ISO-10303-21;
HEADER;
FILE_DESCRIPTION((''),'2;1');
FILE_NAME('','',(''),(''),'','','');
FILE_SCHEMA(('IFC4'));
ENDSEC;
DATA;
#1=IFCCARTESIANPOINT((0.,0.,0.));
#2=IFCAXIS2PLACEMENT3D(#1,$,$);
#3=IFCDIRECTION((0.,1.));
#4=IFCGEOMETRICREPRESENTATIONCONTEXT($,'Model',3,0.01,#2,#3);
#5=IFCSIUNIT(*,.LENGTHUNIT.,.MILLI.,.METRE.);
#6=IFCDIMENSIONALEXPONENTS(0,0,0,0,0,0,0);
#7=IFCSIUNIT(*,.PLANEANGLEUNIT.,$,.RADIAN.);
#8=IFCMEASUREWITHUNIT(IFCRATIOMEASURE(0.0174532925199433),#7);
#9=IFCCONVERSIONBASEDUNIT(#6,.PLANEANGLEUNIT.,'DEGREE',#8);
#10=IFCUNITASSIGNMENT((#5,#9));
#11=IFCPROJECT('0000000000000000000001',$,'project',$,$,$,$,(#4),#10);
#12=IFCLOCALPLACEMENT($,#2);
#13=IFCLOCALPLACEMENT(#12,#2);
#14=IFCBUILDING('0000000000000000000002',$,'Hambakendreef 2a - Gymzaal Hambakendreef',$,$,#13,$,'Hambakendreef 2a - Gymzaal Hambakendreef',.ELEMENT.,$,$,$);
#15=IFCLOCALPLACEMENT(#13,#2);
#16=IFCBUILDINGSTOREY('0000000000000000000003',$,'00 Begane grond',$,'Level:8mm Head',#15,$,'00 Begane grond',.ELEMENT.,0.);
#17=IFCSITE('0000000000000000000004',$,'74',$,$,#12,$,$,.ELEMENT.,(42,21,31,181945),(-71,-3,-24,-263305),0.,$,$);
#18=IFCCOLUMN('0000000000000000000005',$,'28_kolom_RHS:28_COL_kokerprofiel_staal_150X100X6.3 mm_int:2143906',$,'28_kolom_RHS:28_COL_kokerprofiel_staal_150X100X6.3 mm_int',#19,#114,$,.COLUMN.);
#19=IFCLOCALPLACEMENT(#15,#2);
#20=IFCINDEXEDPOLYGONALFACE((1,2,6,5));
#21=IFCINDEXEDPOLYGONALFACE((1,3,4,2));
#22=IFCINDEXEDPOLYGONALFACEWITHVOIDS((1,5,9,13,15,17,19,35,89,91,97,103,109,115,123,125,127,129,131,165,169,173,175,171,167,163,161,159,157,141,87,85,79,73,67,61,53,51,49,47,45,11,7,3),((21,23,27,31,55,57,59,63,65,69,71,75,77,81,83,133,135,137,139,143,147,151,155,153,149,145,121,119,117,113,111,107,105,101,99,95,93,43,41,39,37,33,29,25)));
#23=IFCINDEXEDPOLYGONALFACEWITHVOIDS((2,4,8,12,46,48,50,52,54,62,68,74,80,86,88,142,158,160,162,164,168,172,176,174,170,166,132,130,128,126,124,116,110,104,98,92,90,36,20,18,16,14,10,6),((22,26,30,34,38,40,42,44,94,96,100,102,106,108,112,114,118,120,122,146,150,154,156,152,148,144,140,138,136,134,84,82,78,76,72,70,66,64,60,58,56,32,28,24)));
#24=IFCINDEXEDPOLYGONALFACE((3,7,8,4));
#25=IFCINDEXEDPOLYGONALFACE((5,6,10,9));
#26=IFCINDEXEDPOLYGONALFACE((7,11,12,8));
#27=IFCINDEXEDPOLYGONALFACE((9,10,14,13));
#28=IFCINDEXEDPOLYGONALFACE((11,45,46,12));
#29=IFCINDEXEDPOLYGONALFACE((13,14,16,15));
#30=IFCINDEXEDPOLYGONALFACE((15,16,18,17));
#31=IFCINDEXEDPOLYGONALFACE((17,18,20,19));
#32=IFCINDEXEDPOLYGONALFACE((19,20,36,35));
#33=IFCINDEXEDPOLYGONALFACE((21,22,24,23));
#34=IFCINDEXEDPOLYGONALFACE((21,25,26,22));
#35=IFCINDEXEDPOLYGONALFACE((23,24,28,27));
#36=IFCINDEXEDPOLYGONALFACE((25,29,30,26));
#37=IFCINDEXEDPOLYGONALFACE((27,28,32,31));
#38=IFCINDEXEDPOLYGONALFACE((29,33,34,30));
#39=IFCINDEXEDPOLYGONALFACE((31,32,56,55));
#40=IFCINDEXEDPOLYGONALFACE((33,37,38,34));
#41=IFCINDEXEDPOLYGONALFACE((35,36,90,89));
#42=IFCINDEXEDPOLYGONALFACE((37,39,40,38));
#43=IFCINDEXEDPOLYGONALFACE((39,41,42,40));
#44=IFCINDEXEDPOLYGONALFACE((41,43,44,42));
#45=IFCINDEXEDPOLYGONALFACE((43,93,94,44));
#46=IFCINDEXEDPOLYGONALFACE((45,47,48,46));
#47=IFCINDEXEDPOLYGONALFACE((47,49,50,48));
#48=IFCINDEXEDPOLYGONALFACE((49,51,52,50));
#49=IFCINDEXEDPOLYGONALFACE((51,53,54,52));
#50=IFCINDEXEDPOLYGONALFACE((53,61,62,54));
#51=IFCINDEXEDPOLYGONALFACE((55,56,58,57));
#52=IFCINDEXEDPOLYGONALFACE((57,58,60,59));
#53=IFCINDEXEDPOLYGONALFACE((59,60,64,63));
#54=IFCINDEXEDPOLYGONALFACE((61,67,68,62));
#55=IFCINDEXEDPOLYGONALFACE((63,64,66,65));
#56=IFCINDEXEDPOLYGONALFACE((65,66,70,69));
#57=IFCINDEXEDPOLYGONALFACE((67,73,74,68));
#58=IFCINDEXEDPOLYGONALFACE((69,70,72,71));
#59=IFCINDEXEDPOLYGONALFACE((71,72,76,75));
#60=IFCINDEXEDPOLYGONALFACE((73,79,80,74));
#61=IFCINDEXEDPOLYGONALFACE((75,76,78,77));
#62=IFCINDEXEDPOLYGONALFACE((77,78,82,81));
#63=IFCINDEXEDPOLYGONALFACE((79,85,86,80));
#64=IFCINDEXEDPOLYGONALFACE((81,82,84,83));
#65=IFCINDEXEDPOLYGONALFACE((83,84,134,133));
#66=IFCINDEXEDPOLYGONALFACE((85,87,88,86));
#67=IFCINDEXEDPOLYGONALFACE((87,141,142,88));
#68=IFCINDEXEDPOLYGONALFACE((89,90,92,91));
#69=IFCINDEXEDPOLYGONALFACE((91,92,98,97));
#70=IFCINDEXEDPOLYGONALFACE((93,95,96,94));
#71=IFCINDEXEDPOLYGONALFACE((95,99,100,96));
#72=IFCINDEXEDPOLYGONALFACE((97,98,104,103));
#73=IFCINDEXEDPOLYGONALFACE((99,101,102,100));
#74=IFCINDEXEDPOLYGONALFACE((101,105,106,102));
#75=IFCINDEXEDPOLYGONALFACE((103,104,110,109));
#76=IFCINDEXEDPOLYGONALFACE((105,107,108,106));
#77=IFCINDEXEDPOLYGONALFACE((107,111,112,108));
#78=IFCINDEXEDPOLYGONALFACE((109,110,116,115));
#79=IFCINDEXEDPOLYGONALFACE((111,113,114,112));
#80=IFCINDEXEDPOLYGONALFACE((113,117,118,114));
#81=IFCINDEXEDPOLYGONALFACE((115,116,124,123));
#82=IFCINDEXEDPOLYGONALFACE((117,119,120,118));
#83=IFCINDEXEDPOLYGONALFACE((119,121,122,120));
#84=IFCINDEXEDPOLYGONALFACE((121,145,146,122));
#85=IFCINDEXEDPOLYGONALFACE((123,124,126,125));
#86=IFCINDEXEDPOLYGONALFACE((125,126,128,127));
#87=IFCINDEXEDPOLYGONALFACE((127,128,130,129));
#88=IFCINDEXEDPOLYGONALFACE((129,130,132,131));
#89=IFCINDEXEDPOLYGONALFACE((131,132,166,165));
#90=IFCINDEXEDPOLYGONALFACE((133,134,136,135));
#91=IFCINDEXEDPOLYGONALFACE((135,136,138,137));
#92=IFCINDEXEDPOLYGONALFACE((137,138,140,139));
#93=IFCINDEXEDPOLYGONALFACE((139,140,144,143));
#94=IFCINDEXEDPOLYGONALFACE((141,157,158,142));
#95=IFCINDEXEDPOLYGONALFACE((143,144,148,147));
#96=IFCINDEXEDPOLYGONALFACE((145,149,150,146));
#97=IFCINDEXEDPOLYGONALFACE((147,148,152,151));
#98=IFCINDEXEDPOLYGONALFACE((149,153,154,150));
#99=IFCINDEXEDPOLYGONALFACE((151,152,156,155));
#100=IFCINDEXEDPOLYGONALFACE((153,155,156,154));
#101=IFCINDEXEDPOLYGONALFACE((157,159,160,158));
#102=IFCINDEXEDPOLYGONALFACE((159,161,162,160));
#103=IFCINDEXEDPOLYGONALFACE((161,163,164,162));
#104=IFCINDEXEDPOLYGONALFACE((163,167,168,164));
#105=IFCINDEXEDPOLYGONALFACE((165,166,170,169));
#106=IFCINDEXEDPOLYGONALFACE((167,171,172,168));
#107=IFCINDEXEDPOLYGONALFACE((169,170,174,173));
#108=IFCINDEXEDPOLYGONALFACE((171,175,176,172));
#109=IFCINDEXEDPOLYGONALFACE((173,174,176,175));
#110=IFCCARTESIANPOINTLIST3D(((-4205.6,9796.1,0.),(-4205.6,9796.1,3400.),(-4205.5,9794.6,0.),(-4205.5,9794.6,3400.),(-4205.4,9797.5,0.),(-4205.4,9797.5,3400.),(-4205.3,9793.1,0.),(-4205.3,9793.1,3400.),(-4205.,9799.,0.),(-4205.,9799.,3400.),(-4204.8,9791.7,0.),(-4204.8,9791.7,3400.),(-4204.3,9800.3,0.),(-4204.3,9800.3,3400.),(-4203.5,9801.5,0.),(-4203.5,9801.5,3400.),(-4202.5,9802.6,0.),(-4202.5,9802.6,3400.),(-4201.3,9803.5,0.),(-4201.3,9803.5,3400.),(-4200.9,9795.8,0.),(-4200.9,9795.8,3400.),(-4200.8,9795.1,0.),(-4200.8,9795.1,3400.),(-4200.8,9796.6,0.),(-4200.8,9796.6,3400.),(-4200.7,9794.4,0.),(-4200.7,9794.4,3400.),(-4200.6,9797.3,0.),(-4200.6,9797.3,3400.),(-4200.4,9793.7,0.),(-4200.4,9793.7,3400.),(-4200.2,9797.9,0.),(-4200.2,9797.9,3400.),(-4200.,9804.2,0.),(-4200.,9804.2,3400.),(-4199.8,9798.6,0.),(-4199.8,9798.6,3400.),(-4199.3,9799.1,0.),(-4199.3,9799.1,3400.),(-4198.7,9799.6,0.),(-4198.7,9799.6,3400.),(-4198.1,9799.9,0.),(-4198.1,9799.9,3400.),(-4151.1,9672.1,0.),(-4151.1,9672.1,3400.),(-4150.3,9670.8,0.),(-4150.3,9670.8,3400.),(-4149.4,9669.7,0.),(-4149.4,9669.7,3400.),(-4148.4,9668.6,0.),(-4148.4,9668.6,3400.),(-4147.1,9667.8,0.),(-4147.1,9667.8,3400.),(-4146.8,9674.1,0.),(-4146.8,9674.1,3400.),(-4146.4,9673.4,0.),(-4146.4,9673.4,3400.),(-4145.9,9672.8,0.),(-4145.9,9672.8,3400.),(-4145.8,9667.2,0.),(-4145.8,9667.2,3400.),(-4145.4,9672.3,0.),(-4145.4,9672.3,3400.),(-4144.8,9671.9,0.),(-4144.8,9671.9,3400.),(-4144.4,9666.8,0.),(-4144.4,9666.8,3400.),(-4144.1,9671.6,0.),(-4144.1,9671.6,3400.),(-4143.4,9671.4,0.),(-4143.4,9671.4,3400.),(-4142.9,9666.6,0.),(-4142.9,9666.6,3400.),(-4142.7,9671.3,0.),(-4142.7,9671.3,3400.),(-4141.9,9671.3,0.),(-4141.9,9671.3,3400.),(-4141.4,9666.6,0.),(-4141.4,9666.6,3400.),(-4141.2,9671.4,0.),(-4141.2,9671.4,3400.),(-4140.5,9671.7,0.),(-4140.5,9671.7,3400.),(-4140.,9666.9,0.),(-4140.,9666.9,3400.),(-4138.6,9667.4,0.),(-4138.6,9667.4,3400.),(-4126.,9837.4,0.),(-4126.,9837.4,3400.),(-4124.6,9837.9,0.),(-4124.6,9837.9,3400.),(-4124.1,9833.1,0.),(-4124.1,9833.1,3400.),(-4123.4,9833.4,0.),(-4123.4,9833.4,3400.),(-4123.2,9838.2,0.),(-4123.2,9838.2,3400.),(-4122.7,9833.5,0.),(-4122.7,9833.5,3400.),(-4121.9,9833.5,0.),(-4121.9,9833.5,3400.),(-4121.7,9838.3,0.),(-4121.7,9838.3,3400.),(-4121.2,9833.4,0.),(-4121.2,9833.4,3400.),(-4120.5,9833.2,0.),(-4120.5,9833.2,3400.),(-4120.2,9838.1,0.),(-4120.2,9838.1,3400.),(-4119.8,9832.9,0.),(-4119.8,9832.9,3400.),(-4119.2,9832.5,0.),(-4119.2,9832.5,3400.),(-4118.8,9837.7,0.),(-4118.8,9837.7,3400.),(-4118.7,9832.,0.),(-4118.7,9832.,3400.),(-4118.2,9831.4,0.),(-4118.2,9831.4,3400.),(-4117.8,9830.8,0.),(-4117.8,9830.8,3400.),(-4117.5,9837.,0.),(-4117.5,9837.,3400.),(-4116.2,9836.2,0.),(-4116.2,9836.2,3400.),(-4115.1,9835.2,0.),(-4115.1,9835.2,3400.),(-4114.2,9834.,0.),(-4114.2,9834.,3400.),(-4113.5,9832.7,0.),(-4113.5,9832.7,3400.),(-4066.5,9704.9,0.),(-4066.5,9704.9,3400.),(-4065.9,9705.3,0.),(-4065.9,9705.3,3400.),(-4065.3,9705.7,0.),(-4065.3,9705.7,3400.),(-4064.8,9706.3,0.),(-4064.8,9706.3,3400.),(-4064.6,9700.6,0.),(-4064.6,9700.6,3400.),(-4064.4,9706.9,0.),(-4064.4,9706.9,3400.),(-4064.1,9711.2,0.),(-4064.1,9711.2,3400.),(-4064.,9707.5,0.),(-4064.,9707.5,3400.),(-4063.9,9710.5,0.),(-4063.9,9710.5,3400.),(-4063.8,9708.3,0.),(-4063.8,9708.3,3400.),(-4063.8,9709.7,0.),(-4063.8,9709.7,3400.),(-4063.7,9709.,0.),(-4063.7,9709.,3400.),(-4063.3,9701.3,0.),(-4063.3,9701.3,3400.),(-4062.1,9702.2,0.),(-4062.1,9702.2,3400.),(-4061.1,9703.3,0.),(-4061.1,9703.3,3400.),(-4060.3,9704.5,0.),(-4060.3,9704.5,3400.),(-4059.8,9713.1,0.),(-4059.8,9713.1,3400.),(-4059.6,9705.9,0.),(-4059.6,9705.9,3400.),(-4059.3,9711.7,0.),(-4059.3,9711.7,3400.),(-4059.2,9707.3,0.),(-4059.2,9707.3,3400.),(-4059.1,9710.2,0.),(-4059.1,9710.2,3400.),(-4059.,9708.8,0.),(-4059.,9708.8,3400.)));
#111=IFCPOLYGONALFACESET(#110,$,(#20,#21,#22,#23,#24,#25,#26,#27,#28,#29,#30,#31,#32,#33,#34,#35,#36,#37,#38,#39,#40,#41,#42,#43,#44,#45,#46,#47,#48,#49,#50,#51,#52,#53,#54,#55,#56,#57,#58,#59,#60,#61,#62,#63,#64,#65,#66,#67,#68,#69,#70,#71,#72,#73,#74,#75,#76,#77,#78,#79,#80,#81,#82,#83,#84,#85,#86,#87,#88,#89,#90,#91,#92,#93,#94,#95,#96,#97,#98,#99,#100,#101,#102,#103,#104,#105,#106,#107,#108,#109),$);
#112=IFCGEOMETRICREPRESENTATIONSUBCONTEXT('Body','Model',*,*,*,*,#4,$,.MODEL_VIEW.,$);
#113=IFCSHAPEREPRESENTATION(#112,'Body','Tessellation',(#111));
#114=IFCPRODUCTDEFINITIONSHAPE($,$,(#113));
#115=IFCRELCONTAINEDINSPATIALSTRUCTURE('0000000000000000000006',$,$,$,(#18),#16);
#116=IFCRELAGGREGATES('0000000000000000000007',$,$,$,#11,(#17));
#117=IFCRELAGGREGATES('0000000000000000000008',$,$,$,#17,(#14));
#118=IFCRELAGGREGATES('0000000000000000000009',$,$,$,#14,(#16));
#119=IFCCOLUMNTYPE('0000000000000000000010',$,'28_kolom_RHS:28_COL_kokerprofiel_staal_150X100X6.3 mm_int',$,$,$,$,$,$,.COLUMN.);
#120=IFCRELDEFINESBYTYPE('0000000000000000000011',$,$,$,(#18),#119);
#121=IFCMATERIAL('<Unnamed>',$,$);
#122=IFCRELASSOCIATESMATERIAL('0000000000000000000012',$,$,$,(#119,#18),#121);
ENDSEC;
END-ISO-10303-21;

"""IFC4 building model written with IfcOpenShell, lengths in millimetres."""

from ifc_helpers import new_model, entity, si_unit, converted_unit, direction, frame, origin, place, context, subcontext, project, spatial, indexed_curve, outline, extrude, source, transform, mapped, material, type_object, type_shapes, element, save


model = new_model("IFC4")

# Units and contexts
model_context = context("Model", 3, precision=0.01, world=origin(), true_north=direction((0.0, 1.0)))
body_context = subcontext(model_context, "Body", "Model", "MODEL_VIEW")
ifc_project = project(units=[si_unit("LENGTHUNIT", "METRE", prefix="MILLI"), converted_unit("PLANEANGLEUNIT", "DEGREE", entity("IfcRatioMeasure", 0.0174532925199433), si_unit("PLANEANGLEUNIT", "RADIAN"), dimensions=[0, 0, 0, 0, 0, 0, 0])], contexts=[model_context])

# Site, building, storey
site_placement = place(None, origin())
site = spatial("IfcSite", under=ifc_project, at=site_placement, Name="74", CompositionType="ELEMENT", RefLatitude=(42, 21, 31, 181945), RefLongitude=(-71, -3, -24, -263305), RefElevation=0.0)
building_placement = place(site_placement, origin())
building = spatial("IfcBuilding", under=site, at=building_placement, Name="Hambakendreef 2a - Gymzaal Hambakendreef", LongName="Hambakendreef 2a - Gymzaal Hambakendreef", CompositionType="ELEMENT")
storey_placement = place(building_placement, origin())
storey = spatial("IfcBuildingStorey", under=building, at=storey_placement, Name="00 Begane grond", ObjectType="Level:8mm Head", LongName="00 Begane grond", CompositionType="ELEMENT", Elevation=0.0)

# Column
ifc_material_1 = material(Name="<Unnamed>")
column_type = type_object("IfcColumnType", Name="28_kolom_RHS:28_COL_kokerprofiel_staal_150X100X6.3 mm_int", PredefinedType="COLUMN", material=ifc_material_1)
shared_shape_1 = source(origin(), body_context, "Body", "SweptSolid", [
    extrude(outline(indexed_curve([(-40.5, -75.0), (40.5, -75.0), (42.0, -74.9), (43.5, -74.5), (44.8, -74.0), (46.1, -73.2), (47.2, -72.2), (48.2, -71.1), (49.0, -69.8), (49.5, -68.5), (49.9, -67.0), (50.0, -65.6), (50.0, 65.6), (49.9, 67.0), (49.5, 68.5), (49.0, 69.8), (48.2, 71.1), (47.2, 72.2), (46.1, 73.2), (44.8, 74.0), (43.5, 74.5), (42.0, 74.9), (40.5, 75.0), (-40.5, 75.0), (-42.0, 74.9), (-43.5, 74.5), (-44.8, 74.0), (-46.1, 73.2), (-47.2, 72.2), (-48.2, 71.1), (-49.0, 69.8), (-49.5, 68.5), (-49.9, 67.0), (-50.0, 65.6), (-50.0, -65.6), (-49.9, -67.0), (-49.5, -68.5), (-49.0, -69.8), (-48.2, -71.1), (-47.2, -72.2), (-46.1, -73.2), (-44.8, -74.0), (-43.5, -74.5), (-42.0, -74.9), (-40.5, -75.0)], self_intersect=False), holes=[indexed_curve([(-45.3, 65.5), (-45.2, 66.3), (-45.0, 67.0), (-44.8, 67.7), (-44.4, 68.3), (-43.9, 68.9), (-43.3, 69.4), (-42.7, 69.8), (-42.0, 70.0), (-41.3, 70.2), (-40.6, 70.3), (40.5, 70.3), (41.3, 70.2), (42.0, 70.0), (42.7, 69.8), (43.3, 69.4), (43.9, 68.9), (44.4, 68.3), (44.8, 67.7), (45.0, 67.0), (45.2, 66.3), (45.3, 65.5), (45.3, -65.5), (45.2, -66.3), (45.0, -67.0), (44.8, -67.7), (44.4, -68.3), (43.9, -68.9), (43.3, -69.4), (42.7, -69.8), (42.0, -70.0), (41.3, -70.2), (40.5, -70.3), (-40.6, -70.3), (-41.3, -70.2), (-42.0, -70.0), (-42.7, -69.8), (-43.3, -69.4), (-43.9, -68.9), (-44.4, -68.3), (-44.8, -67.7), (-45.0, -67.0), (-45.2, -66.3), (-45.3, -65.5), (-45.3, 65.5)], self_intersect=False)]), frame((235.6, 34.3, 0.0), z_axis=(0.0, 0.0, 1.0), x_axis=(0.0, 1.0, 0.0)), (0.0, 0.0, 1.0), 3400.0),
])
type_shapes(column_type, [shared_shape_1])
for number, where, z_axis, x_axis, name in (
    (1, (-4260.0, 9953.3, 0.0), (0.0, 0.0, 1.0), (0.40959, -0.91227, 0.0), "28_kolom_RHS:28_COL_kokerprofiel_staal_150X100X6.3 mm_int:2143906"),
):
    element("IfcColumn", number, at=place(storey_placement, frame(where, z_axis=z_axis, x_axis=x_axis)), inside=storey, type_object=column_type, material=ifc_material_1, Name=name, ObjectType="28_kolom_RHS:28_COL_kokerprofiel_staal_150X100X6.3 mm_int", PredefinedType="COLUMN", context=body_context, shape_type="MappedRepresentation", body=[
        mapped(shared_shape_1, transform((0.0, 0.0, 0.0), scale=1.0)),
    ])

save(model, "model.ifc")
